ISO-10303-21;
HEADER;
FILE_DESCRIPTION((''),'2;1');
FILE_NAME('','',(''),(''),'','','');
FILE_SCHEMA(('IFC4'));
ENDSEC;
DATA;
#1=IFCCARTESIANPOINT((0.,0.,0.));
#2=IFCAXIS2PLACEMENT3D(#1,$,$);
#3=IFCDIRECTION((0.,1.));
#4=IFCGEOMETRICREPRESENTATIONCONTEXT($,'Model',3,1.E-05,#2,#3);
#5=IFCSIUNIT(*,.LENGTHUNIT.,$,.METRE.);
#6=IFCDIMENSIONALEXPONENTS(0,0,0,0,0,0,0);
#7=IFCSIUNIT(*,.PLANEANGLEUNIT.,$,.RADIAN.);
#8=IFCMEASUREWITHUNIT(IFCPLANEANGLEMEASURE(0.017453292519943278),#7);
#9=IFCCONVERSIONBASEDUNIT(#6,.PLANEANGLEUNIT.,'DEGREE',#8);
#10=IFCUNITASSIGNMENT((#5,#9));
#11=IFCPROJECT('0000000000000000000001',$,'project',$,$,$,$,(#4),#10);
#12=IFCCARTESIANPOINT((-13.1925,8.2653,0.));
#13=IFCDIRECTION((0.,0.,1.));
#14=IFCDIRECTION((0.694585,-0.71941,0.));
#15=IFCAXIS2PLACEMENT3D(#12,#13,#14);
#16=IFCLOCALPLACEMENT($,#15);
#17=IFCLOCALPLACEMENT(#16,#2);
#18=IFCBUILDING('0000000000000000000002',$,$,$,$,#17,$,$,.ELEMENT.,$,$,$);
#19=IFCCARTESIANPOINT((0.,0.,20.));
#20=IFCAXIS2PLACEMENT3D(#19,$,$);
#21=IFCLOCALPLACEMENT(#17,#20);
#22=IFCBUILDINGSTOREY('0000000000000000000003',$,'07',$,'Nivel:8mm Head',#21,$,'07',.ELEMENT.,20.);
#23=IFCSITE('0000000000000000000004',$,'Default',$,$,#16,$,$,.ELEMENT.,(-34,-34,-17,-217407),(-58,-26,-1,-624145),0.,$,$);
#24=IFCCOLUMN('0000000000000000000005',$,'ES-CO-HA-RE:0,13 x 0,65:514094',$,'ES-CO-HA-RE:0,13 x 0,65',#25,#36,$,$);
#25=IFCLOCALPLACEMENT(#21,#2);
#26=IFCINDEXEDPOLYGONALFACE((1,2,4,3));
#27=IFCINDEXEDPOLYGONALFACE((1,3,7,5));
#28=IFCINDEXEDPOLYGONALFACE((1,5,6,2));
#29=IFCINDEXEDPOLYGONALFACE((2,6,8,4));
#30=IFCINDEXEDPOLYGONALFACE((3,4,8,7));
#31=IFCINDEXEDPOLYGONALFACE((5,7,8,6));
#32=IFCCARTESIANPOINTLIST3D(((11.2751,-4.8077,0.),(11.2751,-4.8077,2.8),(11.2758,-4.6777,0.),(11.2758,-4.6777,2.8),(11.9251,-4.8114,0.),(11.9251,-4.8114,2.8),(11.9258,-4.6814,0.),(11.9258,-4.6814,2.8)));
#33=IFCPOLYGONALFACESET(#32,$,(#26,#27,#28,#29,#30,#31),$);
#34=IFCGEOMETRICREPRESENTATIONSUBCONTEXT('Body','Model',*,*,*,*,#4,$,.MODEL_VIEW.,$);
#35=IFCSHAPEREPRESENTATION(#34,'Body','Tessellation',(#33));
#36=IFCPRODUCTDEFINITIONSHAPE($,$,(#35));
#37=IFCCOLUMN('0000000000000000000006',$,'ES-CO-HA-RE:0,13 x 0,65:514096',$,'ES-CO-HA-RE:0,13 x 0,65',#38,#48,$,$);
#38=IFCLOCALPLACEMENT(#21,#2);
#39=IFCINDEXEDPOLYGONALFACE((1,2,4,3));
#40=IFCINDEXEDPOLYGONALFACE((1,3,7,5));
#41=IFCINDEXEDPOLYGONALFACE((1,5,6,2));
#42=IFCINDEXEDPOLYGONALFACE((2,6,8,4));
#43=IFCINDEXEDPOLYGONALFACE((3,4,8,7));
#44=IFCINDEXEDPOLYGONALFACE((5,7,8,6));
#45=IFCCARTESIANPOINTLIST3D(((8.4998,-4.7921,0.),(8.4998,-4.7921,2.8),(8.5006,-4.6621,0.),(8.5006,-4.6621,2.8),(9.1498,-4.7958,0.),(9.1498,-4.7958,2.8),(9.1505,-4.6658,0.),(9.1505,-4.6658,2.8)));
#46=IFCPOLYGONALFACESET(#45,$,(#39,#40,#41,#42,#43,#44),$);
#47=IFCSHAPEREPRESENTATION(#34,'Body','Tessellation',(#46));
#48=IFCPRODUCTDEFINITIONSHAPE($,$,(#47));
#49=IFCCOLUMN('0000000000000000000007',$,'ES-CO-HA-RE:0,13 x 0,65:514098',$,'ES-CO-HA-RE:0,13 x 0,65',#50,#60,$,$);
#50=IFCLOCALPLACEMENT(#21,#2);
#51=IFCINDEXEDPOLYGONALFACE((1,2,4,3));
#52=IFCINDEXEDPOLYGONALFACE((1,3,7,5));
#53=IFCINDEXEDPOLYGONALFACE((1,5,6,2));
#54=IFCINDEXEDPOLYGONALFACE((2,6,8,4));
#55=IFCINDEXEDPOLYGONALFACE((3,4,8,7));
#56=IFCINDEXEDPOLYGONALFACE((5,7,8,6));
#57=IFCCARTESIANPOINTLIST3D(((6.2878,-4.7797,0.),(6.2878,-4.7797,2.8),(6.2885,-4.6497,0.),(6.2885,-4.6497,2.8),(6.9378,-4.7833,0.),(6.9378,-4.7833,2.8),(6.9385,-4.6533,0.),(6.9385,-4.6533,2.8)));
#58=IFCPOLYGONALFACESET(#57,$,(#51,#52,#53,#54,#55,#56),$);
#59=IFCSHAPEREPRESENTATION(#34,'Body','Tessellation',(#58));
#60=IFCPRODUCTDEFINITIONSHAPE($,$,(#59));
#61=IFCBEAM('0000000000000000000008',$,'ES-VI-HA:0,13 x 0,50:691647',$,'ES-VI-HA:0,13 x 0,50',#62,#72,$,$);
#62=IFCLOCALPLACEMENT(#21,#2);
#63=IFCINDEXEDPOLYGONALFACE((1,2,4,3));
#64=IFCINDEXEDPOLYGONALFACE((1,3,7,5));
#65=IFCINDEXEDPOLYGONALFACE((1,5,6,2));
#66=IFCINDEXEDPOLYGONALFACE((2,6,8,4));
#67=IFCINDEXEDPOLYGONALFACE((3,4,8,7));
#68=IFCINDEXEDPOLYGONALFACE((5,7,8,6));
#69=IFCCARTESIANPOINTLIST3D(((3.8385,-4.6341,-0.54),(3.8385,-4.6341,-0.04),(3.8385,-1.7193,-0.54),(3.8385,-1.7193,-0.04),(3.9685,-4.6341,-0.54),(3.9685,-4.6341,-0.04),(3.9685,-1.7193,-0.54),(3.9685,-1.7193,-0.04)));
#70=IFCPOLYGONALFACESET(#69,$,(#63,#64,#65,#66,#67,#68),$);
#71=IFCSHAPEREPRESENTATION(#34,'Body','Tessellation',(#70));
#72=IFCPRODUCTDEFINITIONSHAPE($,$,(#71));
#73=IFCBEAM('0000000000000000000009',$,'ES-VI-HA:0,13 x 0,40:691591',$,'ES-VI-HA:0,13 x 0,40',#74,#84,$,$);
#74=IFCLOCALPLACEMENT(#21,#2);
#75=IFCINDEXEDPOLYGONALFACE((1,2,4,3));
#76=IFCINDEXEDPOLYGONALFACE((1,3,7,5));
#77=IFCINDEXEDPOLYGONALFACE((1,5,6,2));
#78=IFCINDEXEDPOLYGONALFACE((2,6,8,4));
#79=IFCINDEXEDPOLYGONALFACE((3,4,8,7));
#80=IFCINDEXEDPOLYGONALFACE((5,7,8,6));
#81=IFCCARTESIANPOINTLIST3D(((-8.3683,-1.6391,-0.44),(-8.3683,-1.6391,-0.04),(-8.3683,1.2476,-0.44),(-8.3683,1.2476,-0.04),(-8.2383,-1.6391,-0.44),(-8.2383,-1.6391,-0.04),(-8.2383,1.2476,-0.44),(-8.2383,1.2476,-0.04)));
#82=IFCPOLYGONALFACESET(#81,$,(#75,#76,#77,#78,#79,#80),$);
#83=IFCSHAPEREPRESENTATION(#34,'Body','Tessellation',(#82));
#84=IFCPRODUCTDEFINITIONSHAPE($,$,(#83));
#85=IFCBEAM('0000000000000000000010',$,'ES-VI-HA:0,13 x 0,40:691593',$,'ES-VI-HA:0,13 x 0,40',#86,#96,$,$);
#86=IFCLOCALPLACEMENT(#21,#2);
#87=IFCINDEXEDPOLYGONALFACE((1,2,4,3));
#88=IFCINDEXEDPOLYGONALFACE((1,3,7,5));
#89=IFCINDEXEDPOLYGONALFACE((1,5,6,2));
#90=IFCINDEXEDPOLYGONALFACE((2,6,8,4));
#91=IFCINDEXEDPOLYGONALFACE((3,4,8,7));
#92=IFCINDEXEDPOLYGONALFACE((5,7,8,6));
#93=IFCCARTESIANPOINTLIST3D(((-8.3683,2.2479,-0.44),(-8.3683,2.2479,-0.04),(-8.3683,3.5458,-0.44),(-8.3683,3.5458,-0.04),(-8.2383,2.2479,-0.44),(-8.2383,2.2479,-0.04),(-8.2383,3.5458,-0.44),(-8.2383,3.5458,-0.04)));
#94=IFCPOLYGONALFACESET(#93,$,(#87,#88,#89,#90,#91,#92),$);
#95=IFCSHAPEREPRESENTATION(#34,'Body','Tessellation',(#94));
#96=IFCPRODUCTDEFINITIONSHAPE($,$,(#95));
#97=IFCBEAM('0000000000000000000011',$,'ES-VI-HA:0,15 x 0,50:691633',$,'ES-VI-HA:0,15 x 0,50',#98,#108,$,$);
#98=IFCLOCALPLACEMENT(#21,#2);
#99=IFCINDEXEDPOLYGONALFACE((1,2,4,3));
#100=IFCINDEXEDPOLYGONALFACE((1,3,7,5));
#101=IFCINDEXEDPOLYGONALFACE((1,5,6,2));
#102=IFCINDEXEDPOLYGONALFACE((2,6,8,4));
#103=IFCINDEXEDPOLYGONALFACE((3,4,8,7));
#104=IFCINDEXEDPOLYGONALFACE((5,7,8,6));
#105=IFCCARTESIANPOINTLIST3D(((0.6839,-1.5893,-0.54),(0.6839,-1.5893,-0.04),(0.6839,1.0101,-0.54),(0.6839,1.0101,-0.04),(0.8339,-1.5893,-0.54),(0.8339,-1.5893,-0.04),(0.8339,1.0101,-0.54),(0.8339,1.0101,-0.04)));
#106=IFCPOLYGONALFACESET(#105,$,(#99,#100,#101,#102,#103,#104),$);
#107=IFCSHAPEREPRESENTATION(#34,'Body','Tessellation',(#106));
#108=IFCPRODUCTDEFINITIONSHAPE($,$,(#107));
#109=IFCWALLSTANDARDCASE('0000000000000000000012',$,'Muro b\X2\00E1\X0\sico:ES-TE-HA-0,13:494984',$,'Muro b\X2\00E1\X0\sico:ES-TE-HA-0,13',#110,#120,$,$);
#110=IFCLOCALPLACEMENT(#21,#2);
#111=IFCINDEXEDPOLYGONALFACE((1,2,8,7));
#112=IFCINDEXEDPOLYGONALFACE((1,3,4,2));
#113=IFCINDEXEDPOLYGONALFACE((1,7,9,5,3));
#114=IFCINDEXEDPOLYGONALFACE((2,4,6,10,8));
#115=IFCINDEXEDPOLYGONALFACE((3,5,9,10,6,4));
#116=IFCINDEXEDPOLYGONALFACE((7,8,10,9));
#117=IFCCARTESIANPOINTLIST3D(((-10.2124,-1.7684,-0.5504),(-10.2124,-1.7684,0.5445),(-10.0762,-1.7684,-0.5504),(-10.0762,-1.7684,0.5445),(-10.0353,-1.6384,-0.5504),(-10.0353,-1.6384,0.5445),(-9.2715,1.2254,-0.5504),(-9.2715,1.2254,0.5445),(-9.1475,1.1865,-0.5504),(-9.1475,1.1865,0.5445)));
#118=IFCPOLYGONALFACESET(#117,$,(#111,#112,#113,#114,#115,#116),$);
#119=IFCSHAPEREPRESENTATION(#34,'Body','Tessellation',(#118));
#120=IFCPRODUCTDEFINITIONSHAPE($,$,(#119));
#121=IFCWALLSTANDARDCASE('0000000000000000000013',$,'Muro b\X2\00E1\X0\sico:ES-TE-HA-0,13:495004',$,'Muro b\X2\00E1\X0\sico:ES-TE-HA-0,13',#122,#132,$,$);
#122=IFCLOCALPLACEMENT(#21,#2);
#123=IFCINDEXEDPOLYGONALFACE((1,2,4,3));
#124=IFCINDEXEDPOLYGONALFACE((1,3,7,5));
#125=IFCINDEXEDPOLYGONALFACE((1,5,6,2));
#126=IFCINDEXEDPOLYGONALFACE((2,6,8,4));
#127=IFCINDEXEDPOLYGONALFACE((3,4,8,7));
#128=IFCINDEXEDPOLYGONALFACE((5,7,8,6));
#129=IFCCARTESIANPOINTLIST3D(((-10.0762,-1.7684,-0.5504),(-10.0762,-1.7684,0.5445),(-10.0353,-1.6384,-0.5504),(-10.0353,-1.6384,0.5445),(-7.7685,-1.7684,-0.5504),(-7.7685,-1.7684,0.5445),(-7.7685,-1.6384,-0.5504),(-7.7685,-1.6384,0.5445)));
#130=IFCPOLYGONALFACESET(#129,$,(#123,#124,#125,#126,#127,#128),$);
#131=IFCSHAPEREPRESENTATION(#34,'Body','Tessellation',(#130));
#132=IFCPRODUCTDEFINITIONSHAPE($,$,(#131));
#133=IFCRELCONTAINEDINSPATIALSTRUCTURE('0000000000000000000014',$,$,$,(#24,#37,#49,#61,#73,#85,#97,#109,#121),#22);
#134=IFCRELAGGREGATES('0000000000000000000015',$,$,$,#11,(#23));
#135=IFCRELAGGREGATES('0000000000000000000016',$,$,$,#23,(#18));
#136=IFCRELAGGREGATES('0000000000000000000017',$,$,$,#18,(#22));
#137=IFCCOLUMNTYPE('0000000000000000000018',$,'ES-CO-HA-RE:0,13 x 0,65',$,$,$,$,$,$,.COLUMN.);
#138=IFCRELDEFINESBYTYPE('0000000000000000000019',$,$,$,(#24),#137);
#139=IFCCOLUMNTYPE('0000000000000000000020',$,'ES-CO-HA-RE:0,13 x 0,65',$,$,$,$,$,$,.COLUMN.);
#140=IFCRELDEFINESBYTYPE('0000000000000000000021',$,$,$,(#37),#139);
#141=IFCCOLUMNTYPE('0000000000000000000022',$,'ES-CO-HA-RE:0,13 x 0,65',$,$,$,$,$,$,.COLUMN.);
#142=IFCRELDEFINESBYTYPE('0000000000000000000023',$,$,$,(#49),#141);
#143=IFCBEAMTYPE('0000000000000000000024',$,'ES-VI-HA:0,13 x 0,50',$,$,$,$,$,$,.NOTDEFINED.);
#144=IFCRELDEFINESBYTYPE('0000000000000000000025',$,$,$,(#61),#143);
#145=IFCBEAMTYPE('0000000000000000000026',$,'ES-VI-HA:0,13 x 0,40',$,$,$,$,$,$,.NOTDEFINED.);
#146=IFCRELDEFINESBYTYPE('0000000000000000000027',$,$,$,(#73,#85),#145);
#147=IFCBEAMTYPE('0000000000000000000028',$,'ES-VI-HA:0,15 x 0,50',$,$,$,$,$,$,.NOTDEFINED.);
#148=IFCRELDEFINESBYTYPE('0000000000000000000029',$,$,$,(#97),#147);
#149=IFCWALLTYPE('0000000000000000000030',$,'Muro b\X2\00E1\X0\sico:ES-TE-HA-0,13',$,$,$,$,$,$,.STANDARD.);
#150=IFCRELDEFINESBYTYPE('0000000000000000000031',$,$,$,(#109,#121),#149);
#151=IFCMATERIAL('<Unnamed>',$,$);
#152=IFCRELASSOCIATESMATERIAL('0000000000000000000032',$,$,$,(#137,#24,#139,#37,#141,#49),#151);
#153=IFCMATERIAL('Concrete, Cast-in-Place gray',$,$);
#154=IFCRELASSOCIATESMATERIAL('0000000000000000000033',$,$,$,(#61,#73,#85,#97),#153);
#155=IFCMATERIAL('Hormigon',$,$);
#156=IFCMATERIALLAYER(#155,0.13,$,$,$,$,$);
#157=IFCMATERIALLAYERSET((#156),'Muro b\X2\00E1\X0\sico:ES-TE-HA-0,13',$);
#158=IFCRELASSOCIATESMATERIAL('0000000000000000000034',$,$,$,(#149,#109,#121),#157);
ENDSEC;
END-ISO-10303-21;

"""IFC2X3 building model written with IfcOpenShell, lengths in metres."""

from ifc_helpers import new_model, entity, si_unit, converted_unit, direction, frame, frame_2d, origin, origin_2d_with_axis, place, context, subcontext, project, spatial, polyline, rectangle, outline, extrude, source, transform, mapped, material, layer, layer_set, layer_usage, type_object, type_shapes, element, save


model = new_model("IFC2X3")

# Units and contexts
model_context = context("Model", 3, precision=1e-05, world=origin(), true_north=direction((0.0, 1.0)))
body_context = subcontext(model_context, "Body", "Model", "MODEL_VIEW")
ifc_project = project(units=[si_unit("LENGTHUNIT", "METRE"), converted_unit("PLANEANGLEUNIT", "DEGREE", entity("IfcPlaneAngleMeasure", 0.017453292519943278), si_unit("PLANEANGLEUNIT", "RADIAN"), dimensions=[0, 0, 0, 0, 0, 0, 0])], contexts=[model_context])

# Site, building, storey
site_placement = place(None, frame((-13.1925, 8.2653, 0.0), z_axis=(0.0, 0.0, 1.0), x_axis=(0.694585, -0.71941, 0.0)))
site = spatial("IfcSite", under=ifc_project, at=site_placement, Name="Default", CompositionType="ELEMENT", RefLatitude=(-34, -34, -17, -217407), RefLongitude=(-58, -26, -1, -624145), RefElevation=0.0)
building_placement = place(site_placement, origin())
building = spatial("IfcBuilding", under=site, at=building_placement, CompositionType="ELEMENT")
storey_placement = place(building_placement, frame((0.0, 0.0, 20.0)))
storey = spatial("IfcBuildingStorey", under=building, at=storey_placement, Name="07", ObjectType="Nivel:8mm Head", LongName="07", CompositionType="ELEMENT", Elevation=20.0)

# Columns
ifc_material_1 = material(Name="<Unnamed>")
column_type_1 = type_object("IfcColumnType", Name="ES-CO-HA-RE:0,13 x 0,65", PredefinedType="COLUMN", material=ifc_material_1)
shared_shape_1 = source(origin(), body_context, "Body", "SweptSolid", [
    extrude(rectangle(XDim=0.65, YDim=0.13, at=frame_2d((0.0, 0.0), x_axis=(1.0, 0.0))), frame((11.6005, -4.7445, 20.0), z_axis=(0.0, 0.0, 1.0), x_axis=(-0.999984, 0.005619, 0.0)), (0.0, 0.0, 1.0), 2.8),
])
type_shapes(column_type_1, [shared_shape_1])
column_1_placement = place(storey_placement, frame((0.0, 0.0, -20.0)))
element("IfcColumn", 1, at=column_1_placement, inside=storey, type_object=column_type_1, material=ifc_material_1, Name="ES-CO-HA-RE:0,13 x 0,65:514094", ObjectType="ES-CO-HA-RE:0,13 x 0,65", context=body_context, shape_type="MappedRepresentation", body=[
    mapped(shared_shape_1, transform((0.0, 0.0, 0.0), scale=1.0)),
])
column_type_2 = type_object("IfcColumnType", Name="ES-CO-HA-RE:0,13 x 0,65", PredefinedType="COLUMN", material=ifc_material_1)
shared_shape_2 = source(origin(), body_context, "Body", "SweptSolid", [
    extrude(rectangle(XDim=0.65, YDim=0.13, at=origin_2d_with_axis()), frame((8.8252, -4.7289, 20.0), z_axis=(0.0, 0.0, 1.0), x_axis=(-0.999984, 0.005619, 0.0)), (0.0, 0.0, 1.0), 2.8),
])
type_shapes(column_type_2, [shared_shape_2])
column_2_placement = place(storey_placement, frame((0.0, 0.0, -20.0)))
element("IfcColumn", 2, at=column_2_placement, inside=storey, type_object=column_type_2, material=ifc_material_1, Name="ES-CO-HA-RE:0,13 x 0,65:514096", ObjectType="ES-CO-HA-RE:0,13 x 0,65", context=body_context, shape_type="MappedRepresentation", body=[
    mapped(shared_shape_2, transform((0.0, 0.0, 0.0), scale=1.0)),
])
column_type_3 = type_object("IfcColumnType", Name="ES-CO-HA-RE:0,13 x 0,65", PredefinedType="COLUMN", material=ifc_material_1)
shared_shape_3 = source(origin(), body_context, "Body", "SweptSolid", [
    extrude(rectangle(XDim=0.65, YDim=0.13, at=frame_2d((0.0, 0.0), x_axis=(1.0, 0.0))), frame((6.6131, -4.7165, 20.0), z_axis=(0.0, 0.0, 1.0), x_axis=(-0.999984, 0.005619, 0.0)), (0.0, 0.0, 1.0), 2.8),
])
type_shapes(column_type_3, [shared_shape_3])
column_3_placement = place(storey_placement, frame((0.0, 0.0, -20.0)))
element("IfcColumn", 3, at=column_3_placement, inside=storey, type_object=column_type_3, material=ifc_material_1, Name="ES-CO-HA-RE:0,13 x 0,65:514098", ObjectType="ES-CO-HA-RE:0,13 x 0,65", context=body_context, shape_type="MappedRepresentation", body=[
    mapped(shared_shape_3, transform((0.0, 0.0, 0.0), scale=1.0)),
])

# Beams
ifc_material_2 = material(Name="Concrete, Cast-in-Place gray")
beam_type_1 = type_object("IfcBeamType", Name="ES-VI-HA:0,13 x 0,50", PredefinedType="NOTDEFINED")
beam_1_placement = place(storey_placement, frame((3.9035, -4.7011, -0.04), z_axis=(0.0, 0.0, 1.0), x_axis=(0.0, 1.0, 0.0)))
element("IfcBeam", 4, at=beam_1_placement, inside=storey, type_object=beam_type_1, material=ifc_material_2, Name="ES-VI-HA:0,13 x 0,50:691647", ObjectType="ES-VI-HA:0,13 x 0,50", context=body_context, shape_type="SweptSolid", body=[
    extrude(rectangle(XDim=0.5, YDim=0.13, at=frame_2d((0.0, 0.0), x_axis=(1.0, 0.0))), frame((0.067, 0.0, -0.25), z_axis=(1.0, 0.0, 0.0), x_axis=(0.0, 0.0, -1.0)), (0.0, 0.0, 1.0), 2.9148),
])
beam_type_2 = type_object("IfcBeamType", Name="ES-VI-HA:0,13 x 0,40", PredefinedType="NOTDEFINED")
beam_2_placement = place(storey_placement, frame((-8.3033, -1.6391, -0.04), z_axis=(0.0, 0.0, 1.0), x_axis=(0.0, 1.0, 0.0)))
element("IfcBeam", 5, at=beam_2_placement, inside=storey, type_object=beam_type_2, material=ifc_material_2, Name="ES-VI-HA:0,13 x 0,40:691591", ObjectType="ES-VI-HA:0,13 x 0,40", context=body_context, shape_type="SweptSolid", body=[
    extrude(rectangle(XDim=0.4, YDim=0.13, at=frame_2d((0.0, 0.0), x_axis=(1.0, 0.0))), frame((0.0, 0.0, -0.2), z_axis=(1.0, 0.0, 0.0), x_axis=(0.0, 0.0, -1.0)), (0.0, 0.0, 1.0), 2.8867),
])
beam_3_placement = place(storey_placement, frame((-8.3033, 2.2479, -0.04), z_axis=(0.0, 0.0, 1.0), x_axis=(0.0, 1.0, 0.0)))
element("IfcBeam", 6, at=beam_3_placement, inside=storey, type_object=beam_type_2, material=ifc_material_2, Name="ES-VI-HA:0,13 x 0,40:691593", ObjectType="ES-VI-HA:0,13 x 0,40", context=body_context, shape_type="SweptSolid", body=[
    extrude(rectangle(XDim=0.4, YDim=0.13, at=frame_2d((0.0, 0.0), x_axis=(1.0, 0.0))), frame((0.0, 0.0, -0.2), z_axis=(1.0, 0.0, 0.0), x_axis=(0.0, 0.0, -1.0)), (0.0, 0.0, 1.0), 1.298),
])
beam_type_3 = type_object("IfcBeamType", Name="ES-VI-HA:0,15 x 0,50", PredefinedType="NOTDEFINED")
beam_4_placement = place(storey_placement, frame((0.7589, -1.6543, -0.04), z_axis=(0.0, 0.0, 1.0), x_axis=(0.0, 1.0, 0.0)))
element("IfcBeam", 7, at=beam_4_placement, inside=storey, type_object=beam_type_3, material=ifc_material_2, Name="ES-VI-HA:0,15 x 0,50:691633", ObjectType="ES-VI-HA:0,15 x 0,50", context=body_context, shape_type="SweptSolid", body=[
    extrude(rectangle(XDim=0.5, YDim=0.15, at=frame_2d((0.0, 0.0), x_axis=(1.0, 0.0))), frame((0.065, 0.0, -0.25), z_axis=(1.0, 0.0, 0.0), x_axis=(0.0, 0.0, -1.0)), (0.0, 0.0, 1.0), 2.5994),
])

# Shared definitions
ifc_material_3 = material(Name="Hormigon")

# Walls
ifc_layer_1 = layer(ifc_material_3, 0.13)
ifc_layer_set_1 = layer_set([ifc_layer_1], Name="Muro básico:ES-TE-HA-0,13")
ifc_layer_usage_1 = layer_usage(ifc_layer_set_1, "AXIS2", "NEGATIVE", 0.065)
wall_type = type_object("IfcWallType", Name="Muro básico:ES-TE-HA-0,13", PredefinedType="STANDARD", material=ifc_layer_set_1)
wall_1_placement = place(storey_placement, frame((-10.1504, -1.7879, -0.5504), z_axis=(0.0, 0.0, 1.0), x_axis=(0.299835, 0.953991, 0.0)))
element("IfcWallStandardCase", 8, at=wall_1_placement, inside=storey, type_object=wall_type, material=ifc_layer_usage_1, Name="Muro básico:ES-TE-HA-0,13:494984", ObjectType="Muro básico:ES-TE-HA-0,13", context=body_context, shape_type="SweptSolid", body=[
    extrude(outline(polyline([(3.1382, -0.065), (3.1382, 0.065), (0.0, 0.065), (0.0409, -0.065), (0.1771, -0.065), (3.1382, -0.065)])), origin(), (0.0, 0.0, 1.0), 1.0949),
])
ifc_layer_usage_2 = layer_usage(ifc_layer_set_1, "AXIS2", "POSITIVE", -0.065)
wall_2_placement = place(storey_placement, frame((-10.0762, -1.7034, -0.5504)))
element("IfcWallStandardCase", 9, at=wall_2_placement, inside=storey, type_object=wall_type, material=ifc_layer_usage_2, Name="Muro básico:ES-TE-HA-0,13:495004", ObjectType="Muro básico:ES-TE-HA-0,13", context=body_context, shape_type="SweptSolid", body=[
    extrude(outline(polyline([(2.3077, -0.065), (2.3077, 0.065), (0.0409, 0.065), (0.0, -0.065), (2.3077, -0.065)])), origin(), (0.0, 0.0, 1.0), 1.0949),
])

save(model, "model.ifc")
